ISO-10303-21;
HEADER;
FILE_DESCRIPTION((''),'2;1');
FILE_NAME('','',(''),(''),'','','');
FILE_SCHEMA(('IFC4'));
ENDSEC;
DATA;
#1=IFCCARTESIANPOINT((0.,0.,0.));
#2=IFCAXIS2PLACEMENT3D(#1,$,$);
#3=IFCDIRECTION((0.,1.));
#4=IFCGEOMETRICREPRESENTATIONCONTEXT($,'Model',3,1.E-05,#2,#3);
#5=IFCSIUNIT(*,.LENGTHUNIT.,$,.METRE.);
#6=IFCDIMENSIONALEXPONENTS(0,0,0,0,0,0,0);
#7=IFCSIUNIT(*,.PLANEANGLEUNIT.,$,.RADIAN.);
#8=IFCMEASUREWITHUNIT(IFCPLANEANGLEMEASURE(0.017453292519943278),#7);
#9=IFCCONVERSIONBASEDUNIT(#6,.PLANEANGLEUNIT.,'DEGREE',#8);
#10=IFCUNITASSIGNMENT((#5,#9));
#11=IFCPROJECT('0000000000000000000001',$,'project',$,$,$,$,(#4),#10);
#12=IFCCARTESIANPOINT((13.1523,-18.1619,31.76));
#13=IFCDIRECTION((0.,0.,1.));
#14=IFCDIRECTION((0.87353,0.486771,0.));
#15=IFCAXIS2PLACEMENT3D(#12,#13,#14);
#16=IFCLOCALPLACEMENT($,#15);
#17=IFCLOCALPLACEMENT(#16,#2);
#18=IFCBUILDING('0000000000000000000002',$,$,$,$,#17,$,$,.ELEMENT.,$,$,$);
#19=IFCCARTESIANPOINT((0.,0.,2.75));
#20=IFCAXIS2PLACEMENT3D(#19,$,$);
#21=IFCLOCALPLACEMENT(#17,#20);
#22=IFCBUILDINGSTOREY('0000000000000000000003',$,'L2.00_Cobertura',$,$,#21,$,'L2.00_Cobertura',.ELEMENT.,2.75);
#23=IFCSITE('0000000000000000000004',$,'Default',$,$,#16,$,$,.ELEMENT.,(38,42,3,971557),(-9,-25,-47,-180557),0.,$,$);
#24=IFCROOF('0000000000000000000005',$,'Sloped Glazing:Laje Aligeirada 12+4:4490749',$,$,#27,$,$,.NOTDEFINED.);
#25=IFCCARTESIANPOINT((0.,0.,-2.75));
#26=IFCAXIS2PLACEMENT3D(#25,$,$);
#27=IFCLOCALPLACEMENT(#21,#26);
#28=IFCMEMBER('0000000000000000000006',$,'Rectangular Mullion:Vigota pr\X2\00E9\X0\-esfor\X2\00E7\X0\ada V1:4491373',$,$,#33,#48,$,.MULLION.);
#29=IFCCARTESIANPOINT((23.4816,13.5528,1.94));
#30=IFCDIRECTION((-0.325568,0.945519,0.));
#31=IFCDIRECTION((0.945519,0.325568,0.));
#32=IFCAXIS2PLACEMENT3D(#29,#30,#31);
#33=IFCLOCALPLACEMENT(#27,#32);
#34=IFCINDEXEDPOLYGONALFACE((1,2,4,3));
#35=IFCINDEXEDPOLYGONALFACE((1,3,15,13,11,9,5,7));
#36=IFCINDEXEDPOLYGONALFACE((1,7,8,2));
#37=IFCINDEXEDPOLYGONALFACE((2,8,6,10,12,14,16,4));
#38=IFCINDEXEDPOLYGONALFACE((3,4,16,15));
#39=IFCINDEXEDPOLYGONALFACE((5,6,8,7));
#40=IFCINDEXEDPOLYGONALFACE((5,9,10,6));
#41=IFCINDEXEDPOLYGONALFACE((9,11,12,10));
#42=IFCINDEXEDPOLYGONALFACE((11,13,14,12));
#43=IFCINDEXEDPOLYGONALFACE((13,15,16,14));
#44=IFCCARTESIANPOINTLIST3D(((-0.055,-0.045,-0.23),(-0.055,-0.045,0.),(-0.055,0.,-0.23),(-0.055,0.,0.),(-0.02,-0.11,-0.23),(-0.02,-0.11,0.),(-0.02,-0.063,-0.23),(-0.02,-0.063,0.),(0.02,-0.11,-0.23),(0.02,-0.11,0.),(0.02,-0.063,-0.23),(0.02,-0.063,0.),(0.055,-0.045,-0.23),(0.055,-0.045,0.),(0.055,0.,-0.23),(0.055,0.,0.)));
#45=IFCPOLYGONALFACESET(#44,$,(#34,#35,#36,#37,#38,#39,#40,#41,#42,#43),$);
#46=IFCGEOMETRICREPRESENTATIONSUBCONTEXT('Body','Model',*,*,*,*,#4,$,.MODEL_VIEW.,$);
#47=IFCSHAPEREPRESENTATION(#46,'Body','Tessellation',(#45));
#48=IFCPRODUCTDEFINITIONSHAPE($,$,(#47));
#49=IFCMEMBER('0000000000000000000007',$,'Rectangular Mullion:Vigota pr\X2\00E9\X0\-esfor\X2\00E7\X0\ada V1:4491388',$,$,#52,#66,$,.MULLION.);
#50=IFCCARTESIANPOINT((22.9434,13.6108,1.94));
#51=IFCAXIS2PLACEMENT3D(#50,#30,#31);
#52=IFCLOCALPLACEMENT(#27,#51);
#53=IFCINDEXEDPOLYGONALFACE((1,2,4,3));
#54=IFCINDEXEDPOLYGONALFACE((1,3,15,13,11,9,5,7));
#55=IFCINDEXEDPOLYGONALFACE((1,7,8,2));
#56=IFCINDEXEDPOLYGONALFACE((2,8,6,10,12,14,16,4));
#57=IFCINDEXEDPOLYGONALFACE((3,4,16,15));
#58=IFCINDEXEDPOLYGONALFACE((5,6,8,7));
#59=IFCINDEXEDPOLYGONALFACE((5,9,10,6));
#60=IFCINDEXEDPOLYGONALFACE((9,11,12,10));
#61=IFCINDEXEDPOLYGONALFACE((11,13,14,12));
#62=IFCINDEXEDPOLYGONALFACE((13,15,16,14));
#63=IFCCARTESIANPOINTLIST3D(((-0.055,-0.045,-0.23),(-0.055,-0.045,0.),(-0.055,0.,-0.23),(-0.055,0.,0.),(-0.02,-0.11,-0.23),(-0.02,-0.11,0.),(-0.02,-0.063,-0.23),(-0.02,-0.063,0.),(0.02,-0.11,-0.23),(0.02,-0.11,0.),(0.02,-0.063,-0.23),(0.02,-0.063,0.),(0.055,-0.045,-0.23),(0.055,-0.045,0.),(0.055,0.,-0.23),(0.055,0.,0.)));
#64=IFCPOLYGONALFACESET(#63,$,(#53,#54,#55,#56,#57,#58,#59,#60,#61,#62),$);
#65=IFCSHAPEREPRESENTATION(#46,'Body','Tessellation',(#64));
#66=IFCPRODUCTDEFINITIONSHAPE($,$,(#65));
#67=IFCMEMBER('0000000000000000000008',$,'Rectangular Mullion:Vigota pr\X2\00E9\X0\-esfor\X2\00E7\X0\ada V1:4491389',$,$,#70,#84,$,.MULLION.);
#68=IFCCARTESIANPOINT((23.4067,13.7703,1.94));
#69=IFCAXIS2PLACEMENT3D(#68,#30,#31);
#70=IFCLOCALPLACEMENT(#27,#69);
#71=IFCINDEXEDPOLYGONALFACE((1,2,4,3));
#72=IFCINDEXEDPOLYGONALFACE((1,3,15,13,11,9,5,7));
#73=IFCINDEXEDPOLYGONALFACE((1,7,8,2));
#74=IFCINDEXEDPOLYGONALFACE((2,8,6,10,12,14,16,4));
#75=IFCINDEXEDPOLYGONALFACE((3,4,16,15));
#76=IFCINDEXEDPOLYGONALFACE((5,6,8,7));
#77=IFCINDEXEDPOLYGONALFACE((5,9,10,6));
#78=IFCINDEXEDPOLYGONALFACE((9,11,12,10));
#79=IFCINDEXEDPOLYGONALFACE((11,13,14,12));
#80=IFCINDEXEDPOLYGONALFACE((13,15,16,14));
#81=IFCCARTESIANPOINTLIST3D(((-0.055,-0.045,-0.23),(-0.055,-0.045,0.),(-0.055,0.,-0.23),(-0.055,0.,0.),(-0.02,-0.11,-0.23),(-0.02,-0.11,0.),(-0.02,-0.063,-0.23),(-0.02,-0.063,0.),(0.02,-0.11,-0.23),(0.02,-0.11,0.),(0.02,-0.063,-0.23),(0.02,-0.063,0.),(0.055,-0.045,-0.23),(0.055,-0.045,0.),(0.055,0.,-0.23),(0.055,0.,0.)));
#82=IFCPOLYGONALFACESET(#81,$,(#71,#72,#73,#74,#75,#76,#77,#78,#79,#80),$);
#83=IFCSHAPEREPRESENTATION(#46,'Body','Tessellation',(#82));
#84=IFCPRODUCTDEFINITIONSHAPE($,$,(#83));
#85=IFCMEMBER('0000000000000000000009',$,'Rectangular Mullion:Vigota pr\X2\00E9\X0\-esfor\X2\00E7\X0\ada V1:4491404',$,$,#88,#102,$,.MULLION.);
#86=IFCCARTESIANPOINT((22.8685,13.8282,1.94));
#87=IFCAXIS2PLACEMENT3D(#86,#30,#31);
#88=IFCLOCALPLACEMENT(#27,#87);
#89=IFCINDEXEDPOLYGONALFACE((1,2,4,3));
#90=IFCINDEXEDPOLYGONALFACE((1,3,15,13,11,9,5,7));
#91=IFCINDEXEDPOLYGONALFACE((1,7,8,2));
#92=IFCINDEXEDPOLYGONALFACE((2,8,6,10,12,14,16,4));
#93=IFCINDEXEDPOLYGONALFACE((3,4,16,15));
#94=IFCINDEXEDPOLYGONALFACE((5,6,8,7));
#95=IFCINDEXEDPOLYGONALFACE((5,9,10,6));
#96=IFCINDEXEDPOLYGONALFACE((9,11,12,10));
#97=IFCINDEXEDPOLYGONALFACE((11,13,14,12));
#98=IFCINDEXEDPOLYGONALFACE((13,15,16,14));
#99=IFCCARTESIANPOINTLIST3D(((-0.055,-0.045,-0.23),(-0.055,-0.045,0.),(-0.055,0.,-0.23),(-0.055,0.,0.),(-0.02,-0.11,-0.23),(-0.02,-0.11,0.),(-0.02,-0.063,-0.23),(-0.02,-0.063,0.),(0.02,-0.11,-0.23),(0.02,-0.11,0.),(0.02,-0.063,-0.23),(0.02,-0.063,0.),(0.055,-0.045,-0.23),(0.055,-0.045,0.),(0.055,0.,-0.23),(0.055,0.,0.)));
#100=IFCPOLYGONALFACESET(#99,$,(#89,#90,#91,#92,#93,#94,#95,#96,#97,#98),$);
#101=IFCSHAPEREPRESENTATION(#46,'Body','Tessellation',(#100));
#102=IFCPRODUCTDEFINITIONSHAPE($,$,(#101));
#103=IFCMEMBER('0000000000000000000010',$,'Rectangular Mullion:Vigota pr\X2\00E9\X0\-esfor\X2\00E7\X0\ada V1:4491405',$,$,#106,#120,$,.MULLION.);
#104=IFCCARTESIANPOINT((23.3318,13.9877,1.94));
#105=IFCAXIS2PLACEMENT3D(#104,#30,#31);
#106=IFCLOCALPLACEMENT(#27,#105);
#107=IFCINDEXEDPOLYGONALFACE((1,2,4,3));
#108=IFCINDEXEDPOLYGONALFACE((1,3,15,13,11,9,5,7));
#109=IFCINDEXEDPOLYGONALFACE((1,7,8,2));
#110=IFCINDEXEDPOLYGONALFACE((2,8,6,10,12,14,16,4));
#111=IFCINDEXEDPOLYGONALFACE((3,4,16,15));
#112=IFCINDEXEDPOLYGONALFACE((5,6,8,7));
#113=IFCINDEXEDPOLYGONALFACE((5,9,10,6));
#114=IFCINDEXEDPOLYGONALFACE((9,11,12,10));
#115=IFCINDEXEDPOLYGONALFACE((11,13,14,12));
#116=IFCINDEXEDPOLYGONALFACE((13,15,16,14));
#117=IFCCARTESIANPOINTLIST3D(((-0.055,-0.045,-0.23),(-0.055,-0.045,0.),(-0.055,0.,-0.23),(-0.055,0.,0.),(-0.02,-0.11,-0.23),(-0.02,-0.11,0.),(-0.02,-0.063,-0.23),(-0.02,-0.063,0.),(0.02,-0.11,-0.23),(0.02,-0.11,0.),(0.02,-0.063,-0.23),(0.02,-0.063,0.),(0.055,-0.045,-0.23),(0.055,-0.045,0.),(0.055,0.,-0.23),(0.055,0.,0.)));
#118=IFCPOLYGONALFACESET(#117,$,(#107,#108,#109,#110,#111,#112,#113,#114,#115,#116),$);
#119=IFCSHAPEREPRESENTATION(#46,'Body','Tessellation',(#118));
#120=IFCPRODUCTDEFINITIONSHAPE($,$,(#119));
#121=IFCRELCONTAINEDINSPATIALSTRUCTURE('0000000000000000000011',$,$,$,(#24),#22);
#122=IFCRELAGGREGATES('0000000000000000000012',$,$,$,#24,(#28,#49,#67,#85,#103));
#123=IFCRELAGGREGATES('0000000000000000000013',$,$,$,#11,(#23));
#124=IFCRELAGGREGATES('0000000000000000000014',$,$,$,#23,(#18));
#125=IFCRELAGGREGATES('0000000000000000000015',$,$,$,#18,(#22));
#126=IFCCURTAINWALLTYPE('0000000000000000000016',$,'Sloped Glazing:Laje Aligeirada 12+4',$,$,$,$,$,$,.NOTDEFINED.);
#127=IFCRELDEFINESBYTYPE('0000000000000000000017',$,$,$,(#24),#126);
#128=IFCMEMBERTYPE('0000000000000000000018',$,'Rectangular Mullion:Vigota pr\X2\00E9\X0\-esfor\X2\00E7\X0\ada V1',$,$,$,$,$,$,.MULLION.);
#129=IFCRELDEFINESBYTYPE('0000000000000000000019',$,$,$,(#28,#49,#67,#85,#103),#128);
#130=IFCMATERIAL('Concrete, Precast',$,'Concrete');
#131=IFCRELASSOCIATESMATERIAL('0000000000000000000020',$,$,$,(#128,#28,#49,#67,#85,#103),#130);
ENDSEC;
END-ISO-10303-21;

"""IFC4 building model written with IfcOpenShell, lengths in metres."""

from ifc_helpers import new_model, entity, si_unit, converted_unit, direction, frame, origin, place, context, subcontext, project, spatial, indexed_curve, outline, extrude, source, transform, mapped, material, type_object, type_shapes, element, aggregate, save


model = new_model("IFC4")

# Units and contexts
model_context = context("Model", 3, precision=1e-05, world=origin(), true_north=direction((0.0, 1.0)))
body_context = subcontext(model_context, "Body", "Model", "MODEL_VIEW")
ifc_project = project(units=[si_unit("LENGTHUNIT", "METRE"), converted_unit("PLANEANGLEUNIT", "DEGREE", entity("IfcPlaneAngleMeasure", 0.017453292519943278), si_unit("PLANEANGLEUNIT", "RADIAN"), dimensions=[0, 0, 0, 0, 0, 0, 0])], contexts=[model_context])

# Site, building, storey
site_placement = place(None, frame((13.1523, -18.1619, 31.76), z_axis=(0.0, 0.0, 1.0), x_axis=(0.87353, 0.486771, 0.0)))
site = spatial("IfcSite", under=ifc_project, at=site_placement, Name="Default", CompositionType="ELEMENT", RefLatitude=(38, 42, 3, 971557), RefLongitude=(-9, -25, -47, -180557), RefElevation=0.0)
building_placement = place(site_placement, origin())
building = spatial("IfcBuilding", under=site, at=building_placement, CompositionType="ELEMENT")
storey_placement = place(building_placement, frame((0.0, 0.0, 2.75)))
storey = spatial("IfcBuildingStorey", under=building, at=storey_placement, Name="L2.00_Cobertura", LongName="L2.00_Cobertura", CompositionType="ELEMENT", Elevation=2.75)

# Roof, members
curtain_wall_type = type_object("IfcCurtainWallType", Name="Sloped Glazing:Laje Aligeirada 12+4", PredefinedType="NOTDEFINED")
roof_placement = place(storey_placement, frame((0.0, 0.0, -2.75)))
roof = element("IfcRoof", 1, at=roof_placement, inside=storey, type_object=curtain_wall_type, Name="Sloped Glazing:Laje Aligeirada 12+4:4490749", PredefinedType="NOTDEFINED")
ifc_material_1 = material(Name="Concrete, Precast", Category="Concrete")
member_type = type_object("IfcMemberType", Name="Rectangular Mullion:Vigota pré-esforçada V1", PredefinedType="MULLION", material=ifc_material_1)
shared_shape_1 = source(origin(), body_context, "Body", "SweptSolid", [
    extrude(outline(indexed_curve([(-0.055, -0.0545), (0.055, -0.0545), (0.055, -0.0095), (0.02, 0.0085), (0.02, 0.0555), (-0.02, 0.0555), (-0.02, 0.0085), (-0.055, -0.0095), (-0.055, -0.0545)], self_intersect=False)), frame((0.0, -0.0545, -0.23), z_axis=(0.0, 0.0, 1.0), x_axis=(-1.0, 0.0, 0.0)), (0.0, 0.0, 1.0), 0.23),
])
type_shapes(member_type, [shared_shape_1])
member_1_placement = place(roof_placement, frame((23.4816, 13.5528, 1.94), z_axis=(-0.325568, 0.945519, 0.0), x_axis=(0.945519, 0.325568, 0.0)))
member_1 = element("IfcMember", 2, at=member_1_placement, type_object=member_type, material=ifc_material_1, Name="Rectangular Mullion:Vigota pré-esforçada V1:4491373", PredefinedType="MULLION", context=body_context, shape_type="MappedRepresentation", body=[
    mapped(shared_shape_1, transform((0.0, 0.0, 0.0), scale=1.0)),
])
member_2_placement = place(roof_placement, frame((22.9434, 13.6108, 1.94), z_axis=(-0.325568, 0.945519, 0.0), x_axis=(0.945519, 0.325568, 0.0)))
member_2 = element("IfcMember", 3, at=member_2_placement, type_object=member_type, material=ifc_material_1, Name="Rectangular Mullion:Vigota pré-esforçada V1:4491388", PredefinedType="MULLION", context=body_context, shape_type="MappedRepresentation", body=[
    mapped(shared_shape_1, transform((0.0, 0.0, 0.0), scale=1.0)),
])
member_3_placement = place(roof_placement, frame((23.4067, 13.7703, 1.94), z_axis=(-0.325568, 0.945519, 0.0), x_axis=(0.945519, 0.325568, 0.0)))
member_3 = element("IfcMember", 4, at=member_3_placement, type_object=member_type, material=ifc_material_1, Name="Rectangular Mullion:Vigota pré-esforçada V1:4491389", PredefinedType="MULLION", context=body_context, shape_type="MappedRepresentation", body=[
    mapped(shared_shape_1, transform((0.0, 0.0, 0.0), scale=1.0)),
])
member_4_placement = place(roof_placement, frame((22.8685, 13.8282, 1.94), z_axis=(-0.325568, 0.945519, 0.0), x_axis=(0.945519, 0.325568, 0.0)))
member_4 = element("IfcMember", 5, at=member_4_placement, type_object=member_type, material=ifc_material_1, Name="Rectangular Mullion:Vigota pré-esforçada V1:4491404", PredefinedType="MULLION", context=body_context, shape_type="MappedRepresentation", body=[
    mapped(shared_shape_1, transform((0.0, 0.0, 0.0), scale=1.0)),
])
member_5_placement = place(roof_placement, frame((23.3318, 13.9877, 1.94), z_axis=(-0.325568, 0.945519, 0.0), x_axis=(0.945519, 0.325568, 0.0)))
member_5 = element("IfcMember", 6, at=member_5_placement, type_object=member_type, material=ifc_material_1, Name="Rectangular Mullion:Vigota pré-esforçada V1:4491405", PredefinedType="MULLION", context=body_context, shape_type="MappedRepresentation", body=[
    mapped(shared_shape_1, transform((0.0, 0.0, 0.0), scale=1.0)),
])
aggregate(roof, [member_1, member_2, member_3, member_4, member_5])

save(model, "model.ifc")
